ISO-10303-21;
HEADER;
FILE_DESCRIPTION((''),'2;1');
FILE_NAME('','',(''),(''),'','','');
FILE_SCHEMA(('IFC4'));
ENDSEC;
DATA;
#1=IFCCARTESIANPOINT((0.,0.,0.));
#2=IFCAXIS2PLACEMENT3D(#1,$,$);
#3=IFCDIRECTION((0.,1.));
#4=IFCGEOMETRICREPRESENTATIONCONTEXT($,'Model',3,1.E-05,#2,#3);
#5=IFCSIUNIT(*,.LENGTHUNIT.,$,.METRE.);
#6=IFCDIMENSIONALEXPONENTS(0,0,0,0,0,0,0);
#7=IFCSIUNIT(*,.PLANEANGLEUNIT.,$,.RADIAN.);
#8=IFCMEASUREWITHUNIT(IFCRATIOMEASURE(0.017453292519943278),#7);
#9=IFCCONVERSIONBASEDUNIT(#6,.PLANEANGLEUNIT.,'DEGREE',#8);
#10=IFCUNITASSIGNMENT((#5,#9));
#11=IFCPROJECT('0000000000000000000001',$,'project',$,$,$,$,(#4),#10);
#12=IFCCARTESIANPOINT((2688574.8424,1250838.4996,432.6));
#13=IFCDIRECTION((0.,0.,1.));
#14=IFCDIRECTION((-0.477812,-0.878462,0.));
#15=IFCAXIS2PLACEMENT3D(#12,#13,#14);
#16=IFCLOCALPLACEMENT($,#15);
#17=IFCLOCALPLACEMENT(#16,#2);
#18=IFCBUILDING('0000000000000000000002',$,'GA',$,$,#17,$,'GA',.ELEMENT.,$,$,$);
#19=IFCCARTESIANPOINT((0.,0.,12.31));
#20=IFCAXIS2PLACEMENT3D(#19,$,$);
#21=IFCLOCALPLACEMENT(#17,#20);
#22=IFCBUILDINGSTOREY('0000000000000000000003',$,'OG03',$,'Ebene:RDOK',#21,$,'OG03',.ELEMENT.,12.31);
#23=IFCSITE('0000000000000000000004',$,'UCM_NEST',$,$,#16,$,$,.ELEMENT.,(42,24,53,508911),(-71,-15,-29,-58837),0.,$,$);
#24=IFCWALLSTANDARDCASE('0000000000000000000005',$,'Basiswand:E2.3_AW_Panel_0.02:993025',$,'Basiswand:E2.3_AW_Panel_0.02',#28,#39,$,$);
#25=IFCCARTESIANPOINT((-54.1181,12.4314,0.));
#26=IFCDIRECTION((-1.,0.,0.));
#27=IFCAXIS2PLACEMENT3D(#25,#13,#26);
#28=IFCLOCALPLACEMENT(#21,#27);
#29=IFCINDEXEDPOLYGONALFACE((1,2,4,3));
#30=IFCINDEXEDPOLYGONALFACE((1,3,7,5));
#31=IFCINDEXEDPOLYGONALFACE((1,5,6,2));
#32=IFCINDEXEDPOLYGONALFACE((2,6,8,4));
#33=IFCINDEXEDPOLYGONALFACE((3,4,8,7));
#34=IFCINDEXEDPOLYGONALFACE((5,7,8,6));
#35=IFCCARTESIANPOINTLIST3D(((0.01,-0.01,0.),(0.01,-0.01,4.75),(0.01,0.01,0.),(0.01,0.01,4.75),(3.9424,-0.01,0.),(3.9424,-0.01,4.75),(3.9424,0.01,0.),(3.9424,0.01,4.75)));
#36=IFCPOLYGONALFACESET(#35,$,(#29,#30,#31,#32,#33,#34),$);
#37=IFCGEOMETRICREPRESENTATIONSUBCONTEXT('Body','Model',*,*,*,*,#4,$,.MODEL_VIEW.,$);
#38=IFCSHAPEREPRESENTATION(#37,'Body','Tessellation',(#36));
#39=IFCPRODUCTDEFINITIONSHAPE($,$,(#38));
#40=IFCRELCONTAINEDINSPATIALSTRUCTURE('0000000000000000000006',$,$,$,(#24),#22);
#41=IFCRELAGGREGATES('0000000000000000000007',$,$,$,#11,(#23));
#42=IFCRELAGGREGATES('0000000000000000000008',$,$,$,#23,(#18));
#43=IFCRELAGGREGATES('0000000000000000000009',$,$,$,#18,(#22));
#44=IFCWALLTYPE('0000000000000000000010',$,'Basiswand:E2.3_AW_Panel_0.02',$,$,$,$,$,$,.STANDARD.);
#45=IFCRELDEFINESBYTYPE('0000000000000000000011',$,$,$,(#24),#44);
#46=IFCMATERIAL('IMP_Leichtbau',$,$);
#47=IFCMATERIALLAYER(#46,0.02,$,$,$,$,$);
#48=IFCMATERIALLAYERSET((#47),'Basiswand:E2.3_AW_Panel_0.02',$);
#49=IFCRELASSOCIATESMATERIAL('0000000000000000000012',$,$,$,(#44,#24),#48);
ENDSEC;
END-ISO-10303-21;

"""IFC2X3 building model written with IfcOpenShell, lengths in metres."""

from ifc_helpers import new_model, entity, si_unit, converted_unit, direction, frame, frame_2d, origin, place, context, subcontext, project, spatial, rectangle, extrude, material, layer, layer_set, layer_usage, type_object, element, save


model = new_model("IFC2X3")

# Units and contexts
model_context = context("Model", 3, precision=1e-05, world=origin(), true_north=direction((0.0, 1.0)))
body_context = subcontext(model_context, "Body", "Model", "MODEL_VIEW")
ifc_project = project(units=[si_unit("LENGTHUNIT", "METRE"), converted_unit("PLANEANGLEUNIT", "DEGREE", entity("IfcRatioMeasure", 0.017453292519943278), si_unit("PLANEANGLEUNIT", "RADIAN"), dimensions=[0, 0, 0, 0, 0, 0, 0])], contexts=[model_context])

# Site, building, storey
site_placement = place(None, frame((2688574.8424, 1250838.4996, 432.6), z_axis=(0.0, 0.0, 1.0), x_axis=(-0.477812, -0.878462, 0.0)))
site = spatial("IfcSite", under=ifc_project, at=site_placement, Name="UCM_NEST", CompositionType="ELEMENT", RefLatitude=(42, 24, 53, 508911), RefLongitude=(-71, -15, -29, -58837), RefElevation=0.0)
building_placement = place(site_placement, origin())
building = spatial("IfcBuilding", under=site, at=building_placement, Name="GA", LongName="GA", CompositionType="ELEMENT")
storey_placement = place(building_placement, frame((0.0, 0.0, 12.31)))
storey = spatial("IfcBuildingStorey", under=building, at=storey_placement, Name="OG03", ObjectType="Ebene:RDOK", LongName="OG03", CompositionType="ELEMENT", Elevation=12.31)

# Wall
ifc_material_1 = material(Name="IMP_Leichtbau")
ifc_layer_1 = layer(ifc_material_1, 0.02)
ifc_layer_set_1 = layer_set([ifc_layer_1], Name="Basiswand:E2.3_AW_Panel_0.02")
ifc_layer_usage_1 = layer_usage(ifc_layer_set_1, "AXIS2", "NEGATIVE", 0.01)
wall_type_1 = type_object("IfcWallType", Name="Basiswand:E2.3_AW_Panel_0.02", PredefinedType="STANDARD", material=ifc_layer_set_1)
wall_1_placement = place(storey_placement, frame((-54.1181, 12.4314, 0.0), z_axis=(0.0, 0.0, 1.0), x_axis=(-1.0, 0.0, 0.0)))
element("IfcWallStandardCase", 1, at=wall_1_placement, inside=storey, type_object=wall_type_1, material=ifc_layer_usage_1, Name="Basiswand:E2.3_AW_Panel_0.02:993025", ObjectType="Basiswand:E2.3_AW_Panel_0.02", context=body_context, shape_type="SweptSolid", body=[
    extrude(rectangle(XDim=3.9324, YDim=0.02, at=frame_2d((1.9762, 0.0), x_axis=(-1.0, 0.0))), origin(), (0.0, 0.0, 1.0), 4.75),
])

save(model, "model.ifc")
